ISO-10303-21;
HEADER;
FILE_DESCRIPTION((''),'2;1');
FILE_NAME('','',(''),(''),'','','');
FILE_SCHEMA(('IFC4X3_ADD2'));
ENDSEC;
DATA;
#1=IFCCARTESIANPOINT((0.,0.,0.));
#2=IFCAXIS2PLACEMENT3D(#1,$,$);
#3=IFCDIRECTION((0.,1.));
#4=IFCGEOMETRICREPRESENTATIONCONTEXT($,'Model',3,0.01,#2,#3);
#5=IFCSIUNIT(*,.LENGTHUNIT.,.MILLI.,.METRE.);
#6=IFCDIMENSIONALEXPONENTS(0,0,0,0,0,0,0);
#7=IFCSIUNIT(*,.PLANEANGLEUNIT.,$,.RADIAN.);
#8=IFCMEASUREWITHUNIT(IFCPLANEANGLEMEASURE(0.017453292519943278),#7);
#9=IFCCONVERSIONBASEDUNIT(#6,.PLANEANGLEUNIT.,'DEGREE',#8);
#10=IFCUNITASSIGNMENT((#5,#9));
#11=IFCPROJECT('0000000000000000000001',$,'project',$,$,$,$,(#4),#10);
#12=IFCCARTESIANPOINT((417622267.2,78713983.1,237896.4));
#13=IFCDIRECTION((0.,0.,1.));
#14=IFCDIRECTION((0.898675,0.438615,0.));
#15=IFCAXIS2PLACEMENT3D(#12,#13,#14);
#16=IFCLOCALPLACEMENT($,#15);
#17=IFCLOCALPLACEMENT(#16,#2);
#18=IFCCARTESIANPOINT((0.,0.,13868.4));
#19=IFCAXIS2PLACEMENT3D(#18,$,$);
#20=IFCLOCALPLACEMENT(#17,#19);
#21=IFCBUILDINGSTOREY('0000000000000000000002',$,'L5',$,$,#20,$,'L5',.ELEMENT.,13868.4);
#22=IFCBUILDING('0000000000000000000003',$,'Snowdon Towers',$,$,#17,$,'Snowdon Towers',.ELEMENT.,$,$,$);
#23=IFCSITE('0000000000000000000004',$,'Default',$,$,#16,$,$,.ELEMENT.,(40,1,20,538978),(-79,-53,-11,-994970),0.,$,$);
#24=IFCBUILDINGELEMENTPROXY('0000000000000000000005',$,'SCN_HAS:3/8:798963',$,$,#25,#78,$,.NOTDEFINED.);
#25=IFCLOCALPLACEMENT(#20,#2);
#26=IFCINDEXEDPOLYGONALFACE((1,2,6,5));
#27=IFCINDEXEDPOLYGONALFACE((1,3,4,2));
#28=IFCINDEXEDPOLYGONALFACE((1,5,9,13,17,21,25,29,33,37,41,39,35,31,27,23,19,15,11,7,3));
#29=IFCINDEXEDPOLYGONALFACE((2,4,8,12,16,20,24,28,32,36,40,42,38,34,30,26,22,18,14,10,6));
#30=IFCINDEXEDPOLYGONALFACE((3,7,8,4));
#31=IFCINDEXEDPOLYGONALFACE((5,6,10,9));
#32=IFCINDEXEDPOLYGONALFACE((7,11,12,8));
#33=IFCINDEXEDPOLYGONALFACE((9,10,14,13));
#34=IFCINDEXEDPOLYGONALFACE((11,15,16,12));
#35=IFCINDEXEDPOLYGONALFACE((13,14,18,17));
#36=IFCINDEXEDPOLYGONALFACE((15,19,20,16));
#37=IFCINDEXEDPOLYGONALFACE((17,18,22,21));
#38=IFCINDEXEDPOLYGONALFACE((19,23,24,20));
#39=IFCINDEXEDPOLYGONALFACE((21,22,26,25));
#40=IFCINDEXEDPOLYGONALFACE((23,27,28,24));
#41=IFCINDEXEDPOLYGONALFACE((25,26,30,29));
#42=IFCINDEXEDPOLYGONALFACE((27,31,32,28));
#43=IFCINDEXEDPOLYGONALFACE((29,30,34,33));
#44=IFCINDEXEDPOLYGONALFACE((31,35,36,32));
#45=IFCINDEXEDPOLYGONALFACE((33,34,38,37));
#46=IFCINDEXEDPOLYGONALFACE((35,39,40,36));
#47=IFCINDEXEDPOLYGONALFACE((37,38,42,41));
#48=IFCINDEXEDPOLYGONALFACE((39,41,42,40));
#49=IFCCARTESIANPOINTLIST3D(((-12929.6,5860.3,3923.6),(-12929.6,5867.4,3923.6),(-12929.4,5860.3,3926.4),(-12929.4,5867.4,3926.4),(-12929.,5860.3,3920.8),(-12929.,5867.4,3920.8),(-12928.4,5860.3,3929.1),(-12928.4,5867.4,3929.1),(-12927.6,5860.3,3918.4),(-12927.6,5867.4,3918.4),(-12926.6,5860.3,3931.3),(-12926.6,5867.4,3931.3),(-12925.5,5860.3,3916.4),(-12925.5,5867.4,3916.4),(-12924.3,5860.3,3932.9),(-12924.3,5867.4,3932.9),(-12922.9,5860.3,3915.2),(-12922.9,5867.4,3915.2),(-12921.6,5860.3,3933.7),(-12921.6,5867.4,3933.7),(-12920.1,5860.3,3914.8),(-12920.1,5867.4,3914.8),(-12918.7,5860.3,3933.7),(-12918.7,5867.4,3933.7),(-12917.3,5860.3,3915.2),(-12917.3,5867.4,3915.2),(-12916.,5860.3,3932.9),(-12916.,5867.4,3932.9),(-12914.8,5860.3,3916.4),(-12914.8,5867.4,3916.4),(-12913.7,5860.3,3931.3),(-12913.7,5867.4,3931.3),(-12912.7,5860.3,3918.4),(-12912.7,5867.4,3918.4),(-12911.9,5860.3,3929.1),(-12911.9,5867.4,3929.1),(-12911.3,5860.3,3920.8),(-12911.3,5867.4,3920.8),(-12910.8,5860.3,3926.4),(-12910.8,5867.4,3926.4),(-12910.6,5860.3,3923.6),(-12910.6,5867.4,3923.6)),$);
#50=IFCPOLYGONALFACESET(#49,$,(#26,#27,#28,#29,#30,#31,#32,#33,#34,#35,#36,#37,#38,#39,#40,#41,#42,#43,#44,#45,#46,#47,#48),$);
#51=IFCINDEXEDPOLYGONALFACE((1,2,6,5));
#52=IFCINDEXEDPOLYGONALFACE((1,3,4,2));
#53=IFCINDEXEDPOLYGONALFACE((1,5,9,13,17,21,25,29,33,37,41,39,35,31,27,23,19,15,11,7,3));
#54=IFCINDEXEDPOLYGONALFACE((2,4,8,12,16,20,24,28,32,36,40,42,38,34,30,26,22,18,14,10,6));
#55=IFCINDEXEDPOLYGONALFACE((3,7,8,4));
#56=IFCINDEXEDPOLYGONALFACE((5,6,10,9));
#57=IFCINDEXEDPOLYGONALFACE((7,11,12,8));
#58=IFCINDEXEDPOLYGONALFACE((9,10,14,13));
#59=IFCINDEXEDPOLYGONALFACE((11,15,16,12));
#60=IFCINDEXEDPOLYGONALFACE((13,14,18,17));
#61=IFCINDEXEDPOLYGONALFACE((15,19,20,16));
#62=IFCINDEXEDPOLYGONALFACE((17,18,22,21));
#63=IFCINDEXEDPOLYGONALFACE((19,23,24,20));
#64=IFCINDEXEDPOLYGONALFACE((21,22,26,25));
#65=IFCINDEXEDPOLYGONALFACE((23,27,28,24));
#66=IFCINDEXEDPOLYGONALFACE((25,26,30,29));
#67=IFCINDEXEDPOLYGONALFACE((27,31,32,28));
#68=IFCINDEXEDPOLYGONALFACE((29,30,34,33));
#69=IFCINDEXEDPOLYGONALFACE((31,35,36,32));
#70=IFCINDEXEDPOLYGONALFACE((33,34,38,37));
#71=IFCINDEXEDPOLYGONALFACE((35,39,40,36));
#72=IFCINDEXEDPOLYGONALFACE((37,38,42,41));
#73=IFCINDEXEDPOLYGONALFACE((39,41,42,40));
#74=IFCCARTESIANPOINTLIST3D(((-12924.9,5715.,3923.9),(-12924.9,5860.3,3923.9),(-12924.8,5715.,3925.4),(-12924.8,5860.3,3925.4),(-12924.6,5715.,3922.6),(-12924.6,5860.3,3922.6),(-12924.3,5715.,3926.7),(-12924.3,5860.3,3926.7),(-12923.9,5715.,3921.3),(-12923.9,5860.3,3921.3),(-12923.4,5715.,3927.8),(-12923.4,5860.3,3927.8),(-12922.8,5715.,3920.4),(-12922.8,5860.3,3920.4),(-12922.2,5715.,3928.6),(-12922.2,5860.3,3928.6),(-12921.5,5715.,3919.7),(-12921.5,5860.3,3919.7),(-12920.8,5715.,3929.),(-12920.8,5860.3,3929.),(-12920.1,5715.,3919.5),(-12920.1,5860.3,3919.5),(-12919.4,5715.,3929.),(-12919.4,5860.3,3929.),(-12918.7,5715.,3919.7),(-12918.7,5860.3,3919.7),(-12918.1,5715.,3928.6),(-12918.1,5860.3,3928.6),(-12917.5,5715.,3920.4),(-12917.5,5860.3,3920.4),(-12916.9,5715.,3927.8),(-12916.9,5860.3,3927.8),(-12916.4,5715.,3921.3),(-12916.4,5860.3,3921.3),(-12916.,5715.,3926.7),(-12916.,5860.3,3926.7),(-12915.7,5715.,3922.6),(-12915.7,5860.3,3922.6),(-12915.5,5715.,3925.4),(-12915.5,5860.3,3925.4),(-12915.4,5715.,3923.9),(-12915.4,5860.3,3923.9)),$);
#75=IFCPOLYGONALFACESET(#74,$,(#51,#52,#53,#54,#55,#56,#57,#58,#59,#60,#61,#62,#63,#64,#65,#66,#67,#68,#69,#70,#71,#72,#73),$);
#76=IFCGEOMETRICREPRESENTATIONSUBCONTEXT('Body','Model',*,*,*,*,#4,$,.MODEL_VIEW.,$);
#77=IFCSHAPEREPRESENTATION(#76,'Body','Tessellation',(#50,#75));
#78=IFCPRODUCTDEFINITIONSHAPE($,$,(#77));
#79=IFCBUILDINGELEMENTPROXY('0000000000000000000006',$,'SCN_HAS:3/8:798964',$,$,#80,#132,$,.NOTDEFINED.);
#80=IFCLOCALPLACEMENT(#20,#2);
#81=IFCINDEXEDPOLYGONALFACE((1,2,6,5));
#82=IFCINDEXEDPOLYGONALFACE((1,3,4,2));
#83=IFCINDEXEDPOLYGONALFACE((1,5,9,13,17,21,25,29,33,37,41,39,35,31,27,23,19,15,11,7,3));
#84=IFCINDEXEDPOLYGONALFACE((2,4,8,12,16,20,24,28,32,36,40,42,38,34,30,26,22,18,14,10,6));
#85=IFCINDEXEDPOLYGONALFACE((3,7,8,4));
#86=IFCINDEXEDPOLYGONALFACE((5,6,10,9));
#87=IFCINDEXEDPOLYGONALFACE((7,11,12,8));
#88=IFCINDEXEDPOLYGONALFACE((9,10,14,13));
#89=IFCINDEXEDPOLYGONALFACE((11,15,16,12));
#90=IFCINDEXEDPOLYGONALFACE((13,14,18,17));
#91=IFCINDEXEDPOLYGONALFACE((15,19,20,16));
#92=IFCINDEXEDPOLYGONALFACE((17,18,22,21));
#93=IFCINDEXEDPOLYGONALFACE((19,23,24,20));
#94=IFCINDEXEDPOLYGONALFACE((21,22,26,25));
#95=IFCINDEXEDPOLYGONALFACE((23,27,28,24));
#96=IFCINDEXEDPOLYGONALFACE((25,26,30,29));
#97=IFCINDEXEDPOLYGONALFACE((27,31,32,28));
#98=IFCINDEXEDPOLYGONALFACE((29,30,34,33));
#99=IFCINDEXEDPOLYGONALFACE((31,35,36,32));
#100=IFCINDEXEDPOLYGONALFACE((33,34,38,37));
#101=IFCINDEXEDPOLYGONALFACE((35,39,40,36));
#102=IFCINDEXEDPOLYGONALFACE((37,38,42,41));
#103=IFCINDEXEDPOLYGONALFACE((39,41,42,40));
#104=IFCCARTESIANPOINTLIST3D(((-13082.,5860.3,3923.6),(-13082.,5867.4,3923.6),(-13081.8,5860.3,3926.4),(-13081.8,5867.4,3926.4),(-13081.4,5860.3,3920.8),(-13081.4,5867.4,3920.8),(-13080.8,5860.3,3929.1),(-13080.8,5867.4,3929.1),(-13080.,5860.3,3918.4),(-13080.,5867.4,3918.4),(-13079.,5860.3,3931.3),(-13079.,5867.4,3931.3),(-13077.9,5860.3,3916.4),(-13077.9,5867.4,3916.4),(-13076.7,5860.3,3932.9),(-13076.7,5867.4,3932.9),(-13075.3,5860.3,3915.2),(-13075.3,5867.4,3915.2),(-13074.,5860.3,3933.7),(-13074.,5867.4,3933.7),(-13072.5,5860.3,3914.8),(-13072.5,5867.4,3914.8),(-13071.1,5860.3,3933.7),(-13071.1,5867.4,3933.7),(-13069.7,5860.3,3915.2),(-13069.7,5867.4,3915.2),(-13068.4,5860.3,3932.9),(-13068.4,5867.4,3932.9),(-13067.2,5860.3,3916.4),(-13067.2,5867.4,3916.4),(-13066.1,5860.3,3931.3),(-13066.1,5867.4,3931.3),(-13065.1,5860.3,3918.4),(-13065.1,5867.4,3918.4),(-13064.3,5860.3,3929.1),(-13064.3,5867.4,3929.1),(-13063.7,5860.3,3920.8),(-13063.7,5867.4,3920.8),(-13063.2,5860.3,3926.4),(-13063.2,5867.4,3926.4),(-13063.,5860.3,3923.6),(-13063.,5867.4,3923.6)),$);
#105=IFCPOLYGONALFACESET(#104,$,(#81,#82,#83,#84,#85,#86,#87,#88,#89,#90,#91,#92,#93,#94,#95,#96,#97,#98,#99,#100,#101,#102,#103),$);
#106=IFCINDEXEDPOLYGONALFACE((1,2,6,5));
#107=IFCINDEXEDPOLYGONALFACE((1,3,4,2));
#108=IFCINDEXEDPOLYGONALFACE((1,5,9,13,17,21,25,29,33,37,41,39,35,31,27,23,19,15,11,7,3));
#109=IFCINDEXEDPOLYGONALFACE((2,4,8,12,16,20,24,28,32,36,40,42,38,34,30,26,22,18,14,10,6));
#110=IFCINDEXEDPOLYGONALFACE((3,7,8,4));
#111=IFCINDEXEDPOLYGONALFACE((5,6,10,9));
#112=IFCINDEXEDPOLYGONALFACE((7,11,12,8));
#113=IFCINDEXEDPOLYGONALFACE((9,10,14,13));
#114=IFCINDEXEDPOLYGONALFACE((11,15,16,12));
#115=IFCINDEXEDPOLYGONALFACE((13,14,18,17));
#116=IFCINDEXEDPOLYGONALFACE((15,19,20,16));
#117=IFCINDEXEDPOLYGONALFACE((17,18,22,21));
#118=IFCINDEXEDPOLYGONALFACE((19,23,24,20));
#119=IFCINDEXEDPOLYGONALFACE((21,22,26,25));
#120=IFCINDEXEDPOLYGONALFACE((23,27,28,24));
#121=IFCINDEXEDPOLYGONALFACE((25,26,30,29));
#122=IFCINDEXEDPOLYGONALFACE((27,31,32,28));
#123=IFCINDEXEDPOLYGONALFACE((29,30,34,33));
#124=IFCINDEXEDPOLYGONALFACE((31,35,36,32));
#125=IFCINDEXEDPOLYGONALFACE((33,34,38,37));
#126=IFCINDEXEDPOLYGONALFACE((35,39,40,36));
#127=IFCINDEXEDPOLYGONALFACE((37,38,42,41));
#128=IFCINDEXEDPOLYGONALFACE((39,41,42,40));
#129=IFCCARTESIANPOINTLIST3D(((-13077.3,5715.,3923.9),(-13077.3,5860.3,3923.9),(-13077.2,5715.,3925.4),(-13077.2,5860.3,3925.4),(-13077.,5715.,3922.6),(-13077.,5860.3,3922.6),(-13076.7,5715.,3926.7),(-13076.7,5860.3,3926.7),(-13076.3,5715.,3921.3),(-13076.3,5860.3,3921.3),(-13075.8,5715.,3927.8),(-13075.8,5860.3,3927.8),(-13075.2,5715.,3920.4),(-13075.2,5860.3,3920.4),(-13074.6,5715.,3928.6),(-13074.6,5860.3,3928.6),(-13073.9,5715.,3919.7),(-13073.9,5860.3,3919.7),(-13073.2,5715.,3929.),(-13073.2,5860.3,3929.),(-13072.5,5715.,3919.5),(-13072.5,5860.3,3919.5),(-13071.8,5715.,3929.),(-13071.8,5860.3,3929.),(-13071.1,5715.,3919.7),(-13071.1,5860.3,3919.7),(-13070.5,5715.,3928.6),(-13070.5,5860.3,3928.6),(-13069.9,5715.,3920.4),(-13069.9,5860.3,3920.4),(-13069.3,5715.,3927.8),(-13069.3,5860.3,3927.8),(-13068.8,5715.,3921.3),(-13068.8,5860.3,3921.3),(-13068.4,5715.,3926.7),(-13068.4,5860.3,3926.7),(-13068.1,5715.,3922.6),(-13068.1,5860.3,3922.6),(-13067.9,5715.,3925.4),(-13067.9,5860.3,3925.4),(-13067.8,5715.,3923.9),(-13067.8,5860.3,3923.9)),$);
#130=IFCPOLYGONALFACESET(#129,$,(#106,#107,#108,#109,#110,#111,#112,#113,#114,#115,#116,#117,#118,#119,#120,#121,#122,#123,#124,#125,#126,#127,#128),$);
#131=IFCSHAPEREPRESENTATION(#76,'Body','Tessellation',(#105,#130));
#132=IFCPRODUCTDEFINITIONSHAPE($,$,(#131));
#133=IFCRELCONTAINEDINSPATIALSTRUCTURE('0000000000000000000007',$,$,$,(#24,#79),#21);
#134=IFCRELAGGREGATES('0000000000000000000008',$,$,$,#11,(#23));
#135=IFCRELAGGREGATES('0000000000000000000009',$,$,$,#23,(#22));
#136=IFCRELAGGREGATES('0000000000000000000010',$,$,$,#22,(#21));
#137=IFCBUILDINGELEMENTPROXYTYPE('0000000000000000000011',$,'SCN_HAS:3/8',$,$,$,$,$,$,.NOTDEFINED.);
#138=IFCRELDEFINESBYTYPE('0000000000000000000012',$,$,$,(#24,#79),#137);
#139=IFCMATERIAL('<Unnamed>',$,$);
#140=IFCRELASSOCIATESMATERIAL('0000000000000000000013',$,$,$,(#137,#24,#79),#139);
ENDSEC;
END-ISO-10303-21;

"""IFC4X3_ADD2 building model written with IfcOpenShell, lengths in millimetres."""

from ifc_helpers import new_model, entity, si_unit, converted_unit, direction, frame, frame_2d, origin, place, context, subcontext, project, spatial, circle, extrude, source, transform, mapped, material, type_object, type_shapes, element, save


model = new_model("IFC4X3_ADD2")

# Units and contexts
model_context = context("Model", 3, precision=0.01, world=origin(), true_north=direction((0.0, 1.0)))
body_context = subcontext(model_context, "Body", "Model", "MODEL_VIEW")
ifc_project = project(units=[si_unit("LENGTHUNIT", "METRE", prefix="MILLI"), converted_unit("PLANEANGLEUNIT", "DEGREE", entity("IfcPlaneAngleMeasure", 0.017453292519943278), si_unit("PLANEANGLEUNIT", "RADIAN"), dimensions=[0, 0, 0, 0, 0, 0, 0])], contexts=[model_context])

# Site, building, storey
site_placement = place(None, frame((417622267.2, 78713983.1, 237896.4), z_axis=(0.0, 0.0, 1.0), x_axis=(0.898675, 0.438615, 0.0)))
site = spatial("IfcSite", under=ifc_project, at=site_placement, Name="Default", CompositionType="ELEMENT", RefLatitude=(40, 1, 20, 538978), RefLongitude=(-79, -53, -11, -994970), RefElevation=0.0)
building_placement = place(site_placement, origin())
building = spatial("IfcBuilding", under=site, at=building_placement, Name="Snowdon Towers", LongName="Snowdon Towers", CompositionType="ELEMENT")
storey_placement = place(building_placement, frame((0.0, 0.0, 13868.4)))
storey = spatial("IfcBuildingStorey", under=building, at=storey_placement, Name="L5", LongName="L5", CompositionType="ELEMENT", Elevation=13868.4)

# Building element proxies
ifc_material_1 = material(Name="<Unnamed>")
building_element_proxy_type = type_object("IfcBuildingElementProxyType", Name="SCN_HAS:3/8", PredefinedType="NOTDEFINED", material=ifc_material_1)
shared_shape_1 = source(origin(), body_context, "Body", "SweptSolid", [
    extrude(circle(Radius=9.5, at=frame_2d((0.0, 0.0), x_axis=(1.0, 0.0))), frame((0.0, 0.0, -152.4), z_axis=(0.0, 0.0, 1.0), x_axis=(0.0, -1.0, 0.0)), (0.0, 0.0, 1.0), 7.1),
    extrude(circle(Radius=4.8, at=frame_2d((0.0, 0.0), x_axis=(1.0, 0.0))), frame((0.0, 0.0, -145.3), z_axis=(0.0, 0.0, 1.0), x_axis=(0.0, -1.0, 0.0)), (0.0, 0.0, 1.0), 145.3),
])
type_shapes(building_element_proxy_type, [shared_shape_1])
for number, where, z_axis, x_axis, name in (
    (1, (-12920.1, 5715.0, 3924.3), (0.0, -1.0, 0.0), (1.0, 0.0, 0.0), "SCN_HAS:3/8:798963"),
    (2, (-13072.5, 5715.0, 3924.3), (0.0, -1.0, 0.0), (1.0, 0.0, 0.0), "SCN_HAS:3/8:798964"),
):
    element("IfcBuildingElementProxy", number, at=place(storey_placement, frame(where, z_axis=z_axis, x_axis=x_axis)), inside=storey, type_object=building_element_proxy_type, material=ifc_material_1, Name=name, PredefinedType="NOTDEFINED", context=body_context, shape_type="MappedRepresentation", body=[
        mapped(shared_shape_1, transform((0.0, 0.0, 0.0), scale=1.0)),
    ])

save(model, "model.ifc")
